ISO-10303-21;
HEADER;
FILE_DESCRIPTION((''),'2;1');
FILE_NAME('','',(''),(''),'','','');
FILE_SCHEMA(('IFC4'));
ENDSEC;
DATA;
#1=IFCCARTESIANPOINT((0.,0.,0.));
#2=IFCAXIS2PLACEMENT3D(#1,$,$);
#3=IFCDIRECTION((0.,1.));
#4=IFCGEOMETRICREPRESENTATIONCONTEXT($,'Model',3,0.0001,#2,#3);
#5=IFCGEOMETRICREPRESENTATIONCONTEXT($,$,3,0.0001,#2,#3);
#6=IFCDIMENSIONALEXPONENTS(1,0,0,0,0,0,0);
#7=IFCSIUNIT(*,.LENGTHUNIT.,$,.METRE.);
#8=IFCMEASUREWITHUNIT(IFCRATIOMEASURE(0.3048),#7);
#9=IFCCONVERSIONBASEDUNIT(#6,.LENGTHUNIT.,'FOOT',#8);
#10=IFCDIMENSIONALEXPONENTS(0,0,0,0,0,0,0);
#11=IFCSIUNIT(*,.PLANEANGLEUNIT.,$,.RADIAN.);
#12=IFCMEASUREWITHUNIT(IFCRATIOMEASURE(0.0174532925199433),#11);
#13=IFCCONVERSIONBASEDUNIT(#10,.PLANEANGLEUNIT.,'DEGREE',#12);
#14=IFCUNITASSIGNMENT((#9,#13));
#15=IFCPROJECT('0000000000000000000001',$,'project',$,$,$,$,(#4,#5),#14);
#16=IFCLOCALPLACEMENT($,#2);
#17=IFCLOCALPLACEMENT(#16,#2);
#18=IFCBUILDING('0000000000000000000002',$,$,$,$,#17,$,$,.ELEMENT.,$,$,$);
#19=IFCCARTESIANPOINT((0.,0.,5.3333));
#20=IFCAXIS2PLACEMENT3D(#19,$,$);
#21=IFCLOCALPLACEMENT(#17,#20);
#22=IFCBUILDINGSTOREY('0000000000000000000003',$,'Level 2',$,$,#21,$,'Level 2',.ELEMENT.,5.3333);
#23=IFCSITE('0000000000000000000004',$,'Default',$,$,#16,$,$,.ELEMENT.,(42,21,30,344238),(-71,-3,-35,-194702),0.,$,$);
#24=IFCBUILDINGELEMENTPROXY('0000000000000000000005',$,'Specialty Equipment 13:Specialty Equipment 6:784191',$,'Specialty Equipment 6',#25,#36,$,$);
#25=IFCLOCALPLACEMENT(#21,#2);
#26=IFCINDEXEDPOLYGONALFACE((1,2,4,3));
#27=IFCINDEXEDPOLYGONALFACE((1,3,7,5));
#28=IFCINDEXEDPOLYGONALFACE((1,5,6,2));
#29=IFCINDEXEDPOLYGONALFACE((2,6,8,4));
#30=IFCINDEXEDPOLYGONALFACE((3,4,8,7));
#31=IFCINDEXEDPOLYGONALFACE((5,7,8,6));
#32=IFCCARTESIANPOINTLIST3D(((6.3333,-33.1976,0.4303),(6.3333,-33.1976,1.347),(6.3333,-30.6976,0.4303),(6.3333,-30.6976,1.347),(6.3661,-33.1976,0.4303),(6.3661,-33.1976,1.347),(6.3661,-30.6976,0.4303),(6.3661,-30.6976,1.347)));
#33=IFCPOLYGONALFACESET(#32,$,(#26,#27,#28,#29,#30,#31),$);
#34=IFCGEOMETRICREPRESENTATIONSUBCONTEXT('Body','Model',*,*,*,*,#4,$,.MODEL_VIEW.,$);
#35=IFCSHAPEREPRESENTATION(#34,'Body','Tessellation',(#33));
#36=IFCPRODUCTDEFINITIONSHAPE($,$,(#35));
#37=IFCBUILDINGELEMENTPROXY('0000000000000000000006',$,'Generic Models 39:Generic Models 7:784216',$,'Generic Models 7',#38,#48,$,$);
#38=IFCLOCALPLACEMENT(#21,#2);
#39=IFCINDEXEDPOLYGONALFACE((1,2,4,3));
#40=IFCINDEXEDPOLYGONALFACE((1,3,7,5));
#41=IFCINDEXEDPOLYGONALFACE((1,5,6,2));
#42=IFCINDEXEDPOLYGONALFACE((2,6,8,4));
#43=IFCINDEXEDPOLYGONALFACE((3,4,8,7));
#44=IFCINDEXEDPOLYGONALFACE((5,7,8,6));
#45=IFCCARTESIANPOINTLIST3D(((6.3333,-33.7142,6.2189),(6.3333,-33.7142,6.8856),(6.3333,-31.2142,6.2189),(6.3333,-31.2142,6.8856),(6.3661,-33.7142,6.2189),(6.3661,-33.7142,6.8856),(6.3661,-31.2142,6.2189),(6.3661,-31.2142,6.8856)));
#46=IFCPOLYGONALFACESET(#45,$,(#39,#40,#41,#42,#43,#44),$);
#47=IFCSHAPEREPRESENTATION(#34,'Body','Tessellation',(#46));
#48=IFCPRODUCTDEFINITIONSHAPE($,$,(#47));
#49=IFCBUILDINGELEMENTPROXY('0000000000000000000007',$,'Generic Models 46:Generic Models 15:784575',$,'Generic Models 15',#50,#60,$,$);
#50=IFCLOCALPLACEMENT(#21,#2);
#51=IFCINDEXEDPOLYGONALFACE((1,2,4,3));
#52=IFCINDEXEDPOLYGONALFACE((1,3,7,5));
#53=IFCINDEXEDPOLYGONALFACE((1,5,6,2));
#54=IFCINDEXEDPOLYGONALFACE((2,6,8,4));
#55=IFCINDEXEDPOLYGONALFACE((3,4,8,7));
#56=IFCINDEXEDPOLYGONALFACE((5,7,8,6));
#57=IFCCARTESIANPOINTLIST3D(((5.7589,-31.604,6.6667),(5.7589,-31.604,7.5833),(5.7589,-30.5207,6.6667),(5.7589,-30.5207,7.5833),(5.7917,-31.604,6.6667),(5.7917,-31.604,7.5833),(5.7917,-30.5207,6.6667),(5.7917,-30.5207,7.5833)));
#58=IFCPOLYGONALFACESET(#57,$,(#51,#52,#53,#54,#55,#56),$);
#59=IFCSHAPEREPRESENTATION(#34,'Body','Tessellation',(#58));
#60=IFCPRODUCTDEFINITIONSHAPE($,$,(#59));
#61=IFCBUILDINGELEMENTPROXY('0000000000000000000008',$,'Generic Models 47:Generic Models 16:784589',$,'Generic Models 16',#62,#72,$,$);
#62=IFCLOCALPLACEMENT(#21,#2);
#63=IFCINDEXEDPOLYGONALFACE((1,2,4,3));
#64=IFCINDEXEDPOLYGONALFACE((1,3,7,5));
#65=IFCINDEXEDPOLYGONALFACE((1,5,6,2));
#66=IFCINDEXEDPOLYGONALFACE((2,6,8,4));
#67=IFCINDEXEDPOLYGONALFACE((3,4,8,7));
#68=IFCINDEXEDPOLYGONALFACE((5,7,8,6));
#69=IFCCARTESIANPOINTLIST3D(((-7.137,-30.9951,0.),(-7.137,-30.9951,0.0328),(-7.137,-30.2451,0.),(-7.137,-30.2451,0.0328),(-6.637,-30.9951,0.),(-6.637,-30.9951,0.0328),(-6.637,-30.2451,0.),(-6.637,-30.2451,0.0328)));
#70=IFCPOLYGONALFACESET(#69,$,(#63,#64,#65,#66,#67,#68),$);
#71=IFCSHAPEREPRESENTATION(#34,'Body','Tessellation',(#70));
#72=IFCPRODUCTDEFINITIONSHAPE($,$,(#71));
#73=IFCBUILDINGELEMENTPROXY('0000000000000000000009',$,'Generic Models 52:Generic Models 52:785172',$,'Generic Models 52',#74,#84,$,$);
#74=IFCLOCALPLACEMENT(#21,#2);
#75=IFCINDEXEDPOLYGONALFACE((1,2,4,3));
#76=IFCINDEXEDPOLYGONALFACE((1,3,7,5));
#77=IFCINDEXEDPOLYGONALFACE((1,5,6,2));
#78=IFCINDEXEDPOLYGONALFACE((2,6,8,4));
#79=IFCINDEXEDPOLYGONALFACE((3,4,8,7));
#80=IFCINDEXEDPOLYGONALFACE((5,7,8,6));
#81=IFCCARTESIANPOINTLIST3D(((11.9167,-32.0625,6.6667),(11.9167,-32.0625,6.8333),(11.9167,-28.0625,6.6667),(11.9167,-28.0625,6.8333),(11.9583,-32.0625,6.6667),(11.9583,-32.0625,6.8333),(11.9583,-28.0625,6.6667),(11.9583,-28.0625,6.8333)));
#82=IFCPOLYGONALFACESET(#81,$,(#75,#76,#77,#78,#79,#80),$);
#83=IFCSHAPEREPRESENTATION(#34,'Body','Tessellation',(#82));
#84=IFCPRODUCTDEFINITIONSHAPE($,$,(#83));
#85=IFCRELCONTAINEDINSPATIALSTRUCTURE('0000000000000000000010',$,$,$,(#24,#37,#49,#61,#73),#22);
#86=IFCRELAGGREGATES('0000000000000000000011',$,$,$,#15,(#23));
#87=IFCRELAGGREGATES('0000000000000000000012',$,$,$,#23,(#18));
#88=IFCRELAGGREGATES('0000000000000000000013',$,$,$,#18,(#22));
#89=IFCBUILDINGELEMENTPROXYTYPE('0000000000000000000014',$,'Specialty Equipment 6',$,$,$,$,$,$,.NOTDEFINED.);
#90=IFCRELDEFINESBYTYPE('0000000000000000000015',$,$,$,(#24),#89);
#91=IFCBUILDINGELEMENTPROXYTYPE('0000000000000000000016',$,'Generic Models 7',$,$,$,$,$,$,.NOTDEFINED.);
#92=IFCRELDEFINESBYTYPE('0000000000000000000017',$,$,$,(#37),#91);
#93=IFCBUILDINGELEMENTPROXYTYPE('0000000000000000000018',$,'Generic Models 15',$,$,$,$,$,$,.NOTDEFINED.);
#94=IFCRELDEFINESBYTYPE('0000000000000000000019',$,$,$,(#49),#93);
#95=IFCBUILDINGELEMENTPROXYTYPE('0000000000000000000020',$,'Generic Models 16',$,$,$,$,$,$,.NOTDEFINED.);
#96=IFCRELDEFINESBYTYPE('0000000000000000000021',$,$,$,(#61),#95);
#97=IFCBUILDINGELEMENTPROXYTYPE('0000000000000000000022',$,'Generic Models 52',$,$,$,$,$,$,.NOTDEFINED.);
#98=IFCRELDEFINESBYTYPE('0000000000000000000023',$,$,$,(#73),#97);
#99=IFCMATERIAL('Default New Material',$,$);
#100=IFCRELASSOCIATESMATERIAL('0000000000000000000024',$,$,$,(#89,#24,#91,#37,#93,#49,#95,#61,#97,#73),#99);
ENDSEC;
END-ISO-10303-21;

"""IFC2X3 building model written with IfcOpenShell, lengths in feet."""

from ifc_helpers import new_model, entity, si_unit, converted_unit, direction, frame, frame_2d, origin, origin_2d_with_axis, place, context, subcontext, project, spatial, rectangle, extrude, source, transform, mapped, material, type_object, type_shapes, element, save


model = new_model("IFC2X3")

# Units and contexts
model_context = context("Model", 3, precision=0.0001, world=origin(), true_north=direction((0.0, 1.0)))
context_of_model = context(None, 3, precision=0.0001, world=origin(), true_north=direction((0.0, 1.0)))
body_context = subcontext(model_context, "Body", "Model", "MODEL_VIEW")
ifc_project = project(units=[converted_unit("LENGTHUNIT", "FOOT", entity("IfcRatioMeasure", 0.3048), si_unit("LENGTHUNIT", "METRE"), dimensions=[1, 0, 0, 0, 0, 0, 0]), converted_unit("PLANEANGLEUNIT", "DEGREE", entity("IfcRatioMeasure", 0.0174532925199433), si_unit("PLANEANGLEUNIT", "RADIAN"), dimensions=[0, 0, 0, 0, 0, 0, 0])], contexts=[model_context, context_of_model])

# Site, building, storey
site_placement = place(None, origin())
site = spatial("IfcSite", under=ifc_project, at=site_placement, Name="Default", CompositionType="ELEMENT", RefLatitude=(42, 21, 30, 344238), RefLongitude=(-71, -3, -35, -194702), RefElevation=0.0)
building_placement = place(site_placement, origin())
building = spatial("IfcBuilding", under=site, at=building_placement, CompositionType="ELEMENT")
storey_placement = place(building_placement, frame((0.0, 0.0, 5.3333)))
storey = spatial("IfcBuildingStorey", under=building, at=storey_placement, Name="Level 2", LongName="Level 2", CompositionType="ELEMENT", Elevation=5.3333)

# Shared definitions
ifc_material_1 = material(Name="Default New Material")

# Building element proxies
building_element_proxy_type_1 = type_object("IfcBuildingElementProxyType", Name="Specialty Equipment 6", PredefinedType="NOTDEFINED", material=ifc_material_1)
shared_shape_1 = source(origin(), body_context, "Body", "SweptSolid", [
    extrude(rectangle(XDim=0.0328, YDim=2.5, at=frame_2d((0.0, 0.0), x_axis=(1.0, 0.0))), frame((0.0164, 1.25, 0.0), z_axis=(0.0, 0.0, 1.0), x_axis=(-1.0, 0.0, 0.0)), (0.0, 0.0, 1.0), 0.9167),
])
type_shapes(building_element_proxy_type_1, [shared_shape_1])
proxy_1_placement = place(storey_placement, frame((6.3333, -33.1976, 0.4303)))
element("IfcBuildingElementProxy", 1, at=proxy_1_placement, inside=storey, type_object=building_element_proxy_type_1, material=ifc_material_1, Name="Specialty Equipment 13:Specialty Equipment 6:784191", ObjectType="Specialty Equipment 6", context=body_context, shape_type="MappedRepresentation", body=[
    mapped(shared_shape_1, transform((0.0, 0.0, 0.0), scale=1.0)),
])
building_element_proxy_type_2 = type_object("IfcBuildingElementProxyType", Name="Generic Models 7", PredefinedType="NOTDEFINED", material=ifc_material_1)
shared_shape_2 = source(origin(), body_context, "Body", "SweptSolid", [
    extrude(rectangle(XDim=0.0328, YDim=2.5, at=origin_2d_with_axis()), frame((0.0164, 1.25, 0.0), z_axis=(0.0, 0.0, 1.0), x_axis=(-1.0, 0.0, 0.0)), (0.0, 0.0, 1.0), 0.6667),
])
type_shapes(building_element_proxy_type_2, [shared_shape_2])
proxy_2_placement = place(storey_placement, frame((6.3333, -33.7142, 6.2189)))
element("IfcBuildingElementProxy", 2, at=proxy_2_placement, inside=storey, type_object=building_element_proxy_type_2, material=ifc_material_1, Name="Generic Models 39:Generic Models 7:784216", ObjectType="Generic Models 7", context=body_context, shape_type="MappedRepresentation", body=[
    mapped(shared_shape_2, transform((0.0, 0.0, 0.0), scale=1.0)),
])
building_element_proxy_type_3 = type_object("IfcBuildingElementProxyType", Name="Generic Models 15", PredefinedType="NOTDEFINED", material=ifc_material_1)
shared_shape_3 = source(origin(), body_context, "Body", "SweptSolid", [
    extrude(rectangle(XDim=0.0328, YDim=1.0833, at=frame_2d((0.0, 0.0), x_axis=(1.0, 0.0))), frame((0.0164, 0.5417, 0.0)), (0.0, 0.0, 1.0), 0.9167),
])
type_shapes(building_element_proxy_type_3, [shared_shape_3])
proxy_3_placement = place(storey_placement, frame((5.7589, -31.604, 6.6667)))
element("IfcBuildingElementProxy", 3, at=proxy_3_placement, inside=storey, type_object=building_element_proxy_type_3, material=ifc_material_1, Name="Generic Models 46:Generic Models 15:784575", ObjectType="Generic Models 15", context=body_context, shape_type="MappedRepresentation", body=[
    mapped(shared_shape_3, transform((0.0, 0.0, 0.0), scale=1.0)),
])
building_element_proxy_type_4 = type_object("IfcBuildingElementProxyType", Name="Generic Models 16", PredefinedType="NOTDEFINED", material=ifc_material_1)
shared_shape_4 = source(origin(), body_context, "Body", "SweptSolid", [
    extrude(rectangle(XDim=0.75, YDim=0.5, at=origin_2d_with_axis()), frame((0.25, 0.375, 0.0), z_axis=(0.0, 0.0, 1.0), x_axis=(0.0, -1.0, 0.0)), (0.0, 0.0, 1.0), 0.0328),
])
type_shapes(building_element_proxy_type_4, [shared_shape_4])
proxy_4_placement = place(storey_placement, frame((-7.137, -30.9951, 0.0)))
element("IfcBuildingElementProxy", 4, at=proxy_4_placement, inside=storey, type_object=building_element_proxy_type_4, material=ifc_material_1, Name="Generic Models 47:Generic Models 16:784589", ObjectType="Generic Models 16", context=body_context, shape_type="MappedRepresentation", body=[
    mapped(shared_shape_4, transform((0.0, 0.0, 0.0), scale=1.0)),
])
building_element_proxy_type_5 = type_object("IfcBuildingElementProxyType", Name="Generic Models 52", PredefinedType="NOTDEFINED", material=ifc_material_1)
shared_shape_5 = source(origin(), body_context, "Body", "SweptSolid", [
    extrude(rectangle(XDim=0.0417, YDim=4.0, at=frame_2d((0.0, 0.0), x_axis=(1.0, 0.0))), frame((0.0208, 2.0, 0.0), z_axis=(0.0, 0.0, 1.0), x_axis=(-1.0, 0.0, 0.0)), (0.0, 0.0, 1.0), 0.1667),
])
type_shapes(building_element_proxy_type_5, [shared_shape_5])
proxy_5_placement = place(storey_placement, frame((11.9167, -32.0625, 6.6667)))
element("IfcBuildingElementProxy", 5, at=proxy_5_placement, inside=storey, type_object=building_element_proxy_type_5, material=ifc_material_1, Name="Generic Models 52:Generic Models 52:785172", ObjectType="Generic Models 52", context=body_context, shape_type="MappedRepresentation", body=[
    mapped(shared_shape_5, transform((0.0, 0.0, 0.0), scale=1.0)),
])

save(model, "model.ifc")
